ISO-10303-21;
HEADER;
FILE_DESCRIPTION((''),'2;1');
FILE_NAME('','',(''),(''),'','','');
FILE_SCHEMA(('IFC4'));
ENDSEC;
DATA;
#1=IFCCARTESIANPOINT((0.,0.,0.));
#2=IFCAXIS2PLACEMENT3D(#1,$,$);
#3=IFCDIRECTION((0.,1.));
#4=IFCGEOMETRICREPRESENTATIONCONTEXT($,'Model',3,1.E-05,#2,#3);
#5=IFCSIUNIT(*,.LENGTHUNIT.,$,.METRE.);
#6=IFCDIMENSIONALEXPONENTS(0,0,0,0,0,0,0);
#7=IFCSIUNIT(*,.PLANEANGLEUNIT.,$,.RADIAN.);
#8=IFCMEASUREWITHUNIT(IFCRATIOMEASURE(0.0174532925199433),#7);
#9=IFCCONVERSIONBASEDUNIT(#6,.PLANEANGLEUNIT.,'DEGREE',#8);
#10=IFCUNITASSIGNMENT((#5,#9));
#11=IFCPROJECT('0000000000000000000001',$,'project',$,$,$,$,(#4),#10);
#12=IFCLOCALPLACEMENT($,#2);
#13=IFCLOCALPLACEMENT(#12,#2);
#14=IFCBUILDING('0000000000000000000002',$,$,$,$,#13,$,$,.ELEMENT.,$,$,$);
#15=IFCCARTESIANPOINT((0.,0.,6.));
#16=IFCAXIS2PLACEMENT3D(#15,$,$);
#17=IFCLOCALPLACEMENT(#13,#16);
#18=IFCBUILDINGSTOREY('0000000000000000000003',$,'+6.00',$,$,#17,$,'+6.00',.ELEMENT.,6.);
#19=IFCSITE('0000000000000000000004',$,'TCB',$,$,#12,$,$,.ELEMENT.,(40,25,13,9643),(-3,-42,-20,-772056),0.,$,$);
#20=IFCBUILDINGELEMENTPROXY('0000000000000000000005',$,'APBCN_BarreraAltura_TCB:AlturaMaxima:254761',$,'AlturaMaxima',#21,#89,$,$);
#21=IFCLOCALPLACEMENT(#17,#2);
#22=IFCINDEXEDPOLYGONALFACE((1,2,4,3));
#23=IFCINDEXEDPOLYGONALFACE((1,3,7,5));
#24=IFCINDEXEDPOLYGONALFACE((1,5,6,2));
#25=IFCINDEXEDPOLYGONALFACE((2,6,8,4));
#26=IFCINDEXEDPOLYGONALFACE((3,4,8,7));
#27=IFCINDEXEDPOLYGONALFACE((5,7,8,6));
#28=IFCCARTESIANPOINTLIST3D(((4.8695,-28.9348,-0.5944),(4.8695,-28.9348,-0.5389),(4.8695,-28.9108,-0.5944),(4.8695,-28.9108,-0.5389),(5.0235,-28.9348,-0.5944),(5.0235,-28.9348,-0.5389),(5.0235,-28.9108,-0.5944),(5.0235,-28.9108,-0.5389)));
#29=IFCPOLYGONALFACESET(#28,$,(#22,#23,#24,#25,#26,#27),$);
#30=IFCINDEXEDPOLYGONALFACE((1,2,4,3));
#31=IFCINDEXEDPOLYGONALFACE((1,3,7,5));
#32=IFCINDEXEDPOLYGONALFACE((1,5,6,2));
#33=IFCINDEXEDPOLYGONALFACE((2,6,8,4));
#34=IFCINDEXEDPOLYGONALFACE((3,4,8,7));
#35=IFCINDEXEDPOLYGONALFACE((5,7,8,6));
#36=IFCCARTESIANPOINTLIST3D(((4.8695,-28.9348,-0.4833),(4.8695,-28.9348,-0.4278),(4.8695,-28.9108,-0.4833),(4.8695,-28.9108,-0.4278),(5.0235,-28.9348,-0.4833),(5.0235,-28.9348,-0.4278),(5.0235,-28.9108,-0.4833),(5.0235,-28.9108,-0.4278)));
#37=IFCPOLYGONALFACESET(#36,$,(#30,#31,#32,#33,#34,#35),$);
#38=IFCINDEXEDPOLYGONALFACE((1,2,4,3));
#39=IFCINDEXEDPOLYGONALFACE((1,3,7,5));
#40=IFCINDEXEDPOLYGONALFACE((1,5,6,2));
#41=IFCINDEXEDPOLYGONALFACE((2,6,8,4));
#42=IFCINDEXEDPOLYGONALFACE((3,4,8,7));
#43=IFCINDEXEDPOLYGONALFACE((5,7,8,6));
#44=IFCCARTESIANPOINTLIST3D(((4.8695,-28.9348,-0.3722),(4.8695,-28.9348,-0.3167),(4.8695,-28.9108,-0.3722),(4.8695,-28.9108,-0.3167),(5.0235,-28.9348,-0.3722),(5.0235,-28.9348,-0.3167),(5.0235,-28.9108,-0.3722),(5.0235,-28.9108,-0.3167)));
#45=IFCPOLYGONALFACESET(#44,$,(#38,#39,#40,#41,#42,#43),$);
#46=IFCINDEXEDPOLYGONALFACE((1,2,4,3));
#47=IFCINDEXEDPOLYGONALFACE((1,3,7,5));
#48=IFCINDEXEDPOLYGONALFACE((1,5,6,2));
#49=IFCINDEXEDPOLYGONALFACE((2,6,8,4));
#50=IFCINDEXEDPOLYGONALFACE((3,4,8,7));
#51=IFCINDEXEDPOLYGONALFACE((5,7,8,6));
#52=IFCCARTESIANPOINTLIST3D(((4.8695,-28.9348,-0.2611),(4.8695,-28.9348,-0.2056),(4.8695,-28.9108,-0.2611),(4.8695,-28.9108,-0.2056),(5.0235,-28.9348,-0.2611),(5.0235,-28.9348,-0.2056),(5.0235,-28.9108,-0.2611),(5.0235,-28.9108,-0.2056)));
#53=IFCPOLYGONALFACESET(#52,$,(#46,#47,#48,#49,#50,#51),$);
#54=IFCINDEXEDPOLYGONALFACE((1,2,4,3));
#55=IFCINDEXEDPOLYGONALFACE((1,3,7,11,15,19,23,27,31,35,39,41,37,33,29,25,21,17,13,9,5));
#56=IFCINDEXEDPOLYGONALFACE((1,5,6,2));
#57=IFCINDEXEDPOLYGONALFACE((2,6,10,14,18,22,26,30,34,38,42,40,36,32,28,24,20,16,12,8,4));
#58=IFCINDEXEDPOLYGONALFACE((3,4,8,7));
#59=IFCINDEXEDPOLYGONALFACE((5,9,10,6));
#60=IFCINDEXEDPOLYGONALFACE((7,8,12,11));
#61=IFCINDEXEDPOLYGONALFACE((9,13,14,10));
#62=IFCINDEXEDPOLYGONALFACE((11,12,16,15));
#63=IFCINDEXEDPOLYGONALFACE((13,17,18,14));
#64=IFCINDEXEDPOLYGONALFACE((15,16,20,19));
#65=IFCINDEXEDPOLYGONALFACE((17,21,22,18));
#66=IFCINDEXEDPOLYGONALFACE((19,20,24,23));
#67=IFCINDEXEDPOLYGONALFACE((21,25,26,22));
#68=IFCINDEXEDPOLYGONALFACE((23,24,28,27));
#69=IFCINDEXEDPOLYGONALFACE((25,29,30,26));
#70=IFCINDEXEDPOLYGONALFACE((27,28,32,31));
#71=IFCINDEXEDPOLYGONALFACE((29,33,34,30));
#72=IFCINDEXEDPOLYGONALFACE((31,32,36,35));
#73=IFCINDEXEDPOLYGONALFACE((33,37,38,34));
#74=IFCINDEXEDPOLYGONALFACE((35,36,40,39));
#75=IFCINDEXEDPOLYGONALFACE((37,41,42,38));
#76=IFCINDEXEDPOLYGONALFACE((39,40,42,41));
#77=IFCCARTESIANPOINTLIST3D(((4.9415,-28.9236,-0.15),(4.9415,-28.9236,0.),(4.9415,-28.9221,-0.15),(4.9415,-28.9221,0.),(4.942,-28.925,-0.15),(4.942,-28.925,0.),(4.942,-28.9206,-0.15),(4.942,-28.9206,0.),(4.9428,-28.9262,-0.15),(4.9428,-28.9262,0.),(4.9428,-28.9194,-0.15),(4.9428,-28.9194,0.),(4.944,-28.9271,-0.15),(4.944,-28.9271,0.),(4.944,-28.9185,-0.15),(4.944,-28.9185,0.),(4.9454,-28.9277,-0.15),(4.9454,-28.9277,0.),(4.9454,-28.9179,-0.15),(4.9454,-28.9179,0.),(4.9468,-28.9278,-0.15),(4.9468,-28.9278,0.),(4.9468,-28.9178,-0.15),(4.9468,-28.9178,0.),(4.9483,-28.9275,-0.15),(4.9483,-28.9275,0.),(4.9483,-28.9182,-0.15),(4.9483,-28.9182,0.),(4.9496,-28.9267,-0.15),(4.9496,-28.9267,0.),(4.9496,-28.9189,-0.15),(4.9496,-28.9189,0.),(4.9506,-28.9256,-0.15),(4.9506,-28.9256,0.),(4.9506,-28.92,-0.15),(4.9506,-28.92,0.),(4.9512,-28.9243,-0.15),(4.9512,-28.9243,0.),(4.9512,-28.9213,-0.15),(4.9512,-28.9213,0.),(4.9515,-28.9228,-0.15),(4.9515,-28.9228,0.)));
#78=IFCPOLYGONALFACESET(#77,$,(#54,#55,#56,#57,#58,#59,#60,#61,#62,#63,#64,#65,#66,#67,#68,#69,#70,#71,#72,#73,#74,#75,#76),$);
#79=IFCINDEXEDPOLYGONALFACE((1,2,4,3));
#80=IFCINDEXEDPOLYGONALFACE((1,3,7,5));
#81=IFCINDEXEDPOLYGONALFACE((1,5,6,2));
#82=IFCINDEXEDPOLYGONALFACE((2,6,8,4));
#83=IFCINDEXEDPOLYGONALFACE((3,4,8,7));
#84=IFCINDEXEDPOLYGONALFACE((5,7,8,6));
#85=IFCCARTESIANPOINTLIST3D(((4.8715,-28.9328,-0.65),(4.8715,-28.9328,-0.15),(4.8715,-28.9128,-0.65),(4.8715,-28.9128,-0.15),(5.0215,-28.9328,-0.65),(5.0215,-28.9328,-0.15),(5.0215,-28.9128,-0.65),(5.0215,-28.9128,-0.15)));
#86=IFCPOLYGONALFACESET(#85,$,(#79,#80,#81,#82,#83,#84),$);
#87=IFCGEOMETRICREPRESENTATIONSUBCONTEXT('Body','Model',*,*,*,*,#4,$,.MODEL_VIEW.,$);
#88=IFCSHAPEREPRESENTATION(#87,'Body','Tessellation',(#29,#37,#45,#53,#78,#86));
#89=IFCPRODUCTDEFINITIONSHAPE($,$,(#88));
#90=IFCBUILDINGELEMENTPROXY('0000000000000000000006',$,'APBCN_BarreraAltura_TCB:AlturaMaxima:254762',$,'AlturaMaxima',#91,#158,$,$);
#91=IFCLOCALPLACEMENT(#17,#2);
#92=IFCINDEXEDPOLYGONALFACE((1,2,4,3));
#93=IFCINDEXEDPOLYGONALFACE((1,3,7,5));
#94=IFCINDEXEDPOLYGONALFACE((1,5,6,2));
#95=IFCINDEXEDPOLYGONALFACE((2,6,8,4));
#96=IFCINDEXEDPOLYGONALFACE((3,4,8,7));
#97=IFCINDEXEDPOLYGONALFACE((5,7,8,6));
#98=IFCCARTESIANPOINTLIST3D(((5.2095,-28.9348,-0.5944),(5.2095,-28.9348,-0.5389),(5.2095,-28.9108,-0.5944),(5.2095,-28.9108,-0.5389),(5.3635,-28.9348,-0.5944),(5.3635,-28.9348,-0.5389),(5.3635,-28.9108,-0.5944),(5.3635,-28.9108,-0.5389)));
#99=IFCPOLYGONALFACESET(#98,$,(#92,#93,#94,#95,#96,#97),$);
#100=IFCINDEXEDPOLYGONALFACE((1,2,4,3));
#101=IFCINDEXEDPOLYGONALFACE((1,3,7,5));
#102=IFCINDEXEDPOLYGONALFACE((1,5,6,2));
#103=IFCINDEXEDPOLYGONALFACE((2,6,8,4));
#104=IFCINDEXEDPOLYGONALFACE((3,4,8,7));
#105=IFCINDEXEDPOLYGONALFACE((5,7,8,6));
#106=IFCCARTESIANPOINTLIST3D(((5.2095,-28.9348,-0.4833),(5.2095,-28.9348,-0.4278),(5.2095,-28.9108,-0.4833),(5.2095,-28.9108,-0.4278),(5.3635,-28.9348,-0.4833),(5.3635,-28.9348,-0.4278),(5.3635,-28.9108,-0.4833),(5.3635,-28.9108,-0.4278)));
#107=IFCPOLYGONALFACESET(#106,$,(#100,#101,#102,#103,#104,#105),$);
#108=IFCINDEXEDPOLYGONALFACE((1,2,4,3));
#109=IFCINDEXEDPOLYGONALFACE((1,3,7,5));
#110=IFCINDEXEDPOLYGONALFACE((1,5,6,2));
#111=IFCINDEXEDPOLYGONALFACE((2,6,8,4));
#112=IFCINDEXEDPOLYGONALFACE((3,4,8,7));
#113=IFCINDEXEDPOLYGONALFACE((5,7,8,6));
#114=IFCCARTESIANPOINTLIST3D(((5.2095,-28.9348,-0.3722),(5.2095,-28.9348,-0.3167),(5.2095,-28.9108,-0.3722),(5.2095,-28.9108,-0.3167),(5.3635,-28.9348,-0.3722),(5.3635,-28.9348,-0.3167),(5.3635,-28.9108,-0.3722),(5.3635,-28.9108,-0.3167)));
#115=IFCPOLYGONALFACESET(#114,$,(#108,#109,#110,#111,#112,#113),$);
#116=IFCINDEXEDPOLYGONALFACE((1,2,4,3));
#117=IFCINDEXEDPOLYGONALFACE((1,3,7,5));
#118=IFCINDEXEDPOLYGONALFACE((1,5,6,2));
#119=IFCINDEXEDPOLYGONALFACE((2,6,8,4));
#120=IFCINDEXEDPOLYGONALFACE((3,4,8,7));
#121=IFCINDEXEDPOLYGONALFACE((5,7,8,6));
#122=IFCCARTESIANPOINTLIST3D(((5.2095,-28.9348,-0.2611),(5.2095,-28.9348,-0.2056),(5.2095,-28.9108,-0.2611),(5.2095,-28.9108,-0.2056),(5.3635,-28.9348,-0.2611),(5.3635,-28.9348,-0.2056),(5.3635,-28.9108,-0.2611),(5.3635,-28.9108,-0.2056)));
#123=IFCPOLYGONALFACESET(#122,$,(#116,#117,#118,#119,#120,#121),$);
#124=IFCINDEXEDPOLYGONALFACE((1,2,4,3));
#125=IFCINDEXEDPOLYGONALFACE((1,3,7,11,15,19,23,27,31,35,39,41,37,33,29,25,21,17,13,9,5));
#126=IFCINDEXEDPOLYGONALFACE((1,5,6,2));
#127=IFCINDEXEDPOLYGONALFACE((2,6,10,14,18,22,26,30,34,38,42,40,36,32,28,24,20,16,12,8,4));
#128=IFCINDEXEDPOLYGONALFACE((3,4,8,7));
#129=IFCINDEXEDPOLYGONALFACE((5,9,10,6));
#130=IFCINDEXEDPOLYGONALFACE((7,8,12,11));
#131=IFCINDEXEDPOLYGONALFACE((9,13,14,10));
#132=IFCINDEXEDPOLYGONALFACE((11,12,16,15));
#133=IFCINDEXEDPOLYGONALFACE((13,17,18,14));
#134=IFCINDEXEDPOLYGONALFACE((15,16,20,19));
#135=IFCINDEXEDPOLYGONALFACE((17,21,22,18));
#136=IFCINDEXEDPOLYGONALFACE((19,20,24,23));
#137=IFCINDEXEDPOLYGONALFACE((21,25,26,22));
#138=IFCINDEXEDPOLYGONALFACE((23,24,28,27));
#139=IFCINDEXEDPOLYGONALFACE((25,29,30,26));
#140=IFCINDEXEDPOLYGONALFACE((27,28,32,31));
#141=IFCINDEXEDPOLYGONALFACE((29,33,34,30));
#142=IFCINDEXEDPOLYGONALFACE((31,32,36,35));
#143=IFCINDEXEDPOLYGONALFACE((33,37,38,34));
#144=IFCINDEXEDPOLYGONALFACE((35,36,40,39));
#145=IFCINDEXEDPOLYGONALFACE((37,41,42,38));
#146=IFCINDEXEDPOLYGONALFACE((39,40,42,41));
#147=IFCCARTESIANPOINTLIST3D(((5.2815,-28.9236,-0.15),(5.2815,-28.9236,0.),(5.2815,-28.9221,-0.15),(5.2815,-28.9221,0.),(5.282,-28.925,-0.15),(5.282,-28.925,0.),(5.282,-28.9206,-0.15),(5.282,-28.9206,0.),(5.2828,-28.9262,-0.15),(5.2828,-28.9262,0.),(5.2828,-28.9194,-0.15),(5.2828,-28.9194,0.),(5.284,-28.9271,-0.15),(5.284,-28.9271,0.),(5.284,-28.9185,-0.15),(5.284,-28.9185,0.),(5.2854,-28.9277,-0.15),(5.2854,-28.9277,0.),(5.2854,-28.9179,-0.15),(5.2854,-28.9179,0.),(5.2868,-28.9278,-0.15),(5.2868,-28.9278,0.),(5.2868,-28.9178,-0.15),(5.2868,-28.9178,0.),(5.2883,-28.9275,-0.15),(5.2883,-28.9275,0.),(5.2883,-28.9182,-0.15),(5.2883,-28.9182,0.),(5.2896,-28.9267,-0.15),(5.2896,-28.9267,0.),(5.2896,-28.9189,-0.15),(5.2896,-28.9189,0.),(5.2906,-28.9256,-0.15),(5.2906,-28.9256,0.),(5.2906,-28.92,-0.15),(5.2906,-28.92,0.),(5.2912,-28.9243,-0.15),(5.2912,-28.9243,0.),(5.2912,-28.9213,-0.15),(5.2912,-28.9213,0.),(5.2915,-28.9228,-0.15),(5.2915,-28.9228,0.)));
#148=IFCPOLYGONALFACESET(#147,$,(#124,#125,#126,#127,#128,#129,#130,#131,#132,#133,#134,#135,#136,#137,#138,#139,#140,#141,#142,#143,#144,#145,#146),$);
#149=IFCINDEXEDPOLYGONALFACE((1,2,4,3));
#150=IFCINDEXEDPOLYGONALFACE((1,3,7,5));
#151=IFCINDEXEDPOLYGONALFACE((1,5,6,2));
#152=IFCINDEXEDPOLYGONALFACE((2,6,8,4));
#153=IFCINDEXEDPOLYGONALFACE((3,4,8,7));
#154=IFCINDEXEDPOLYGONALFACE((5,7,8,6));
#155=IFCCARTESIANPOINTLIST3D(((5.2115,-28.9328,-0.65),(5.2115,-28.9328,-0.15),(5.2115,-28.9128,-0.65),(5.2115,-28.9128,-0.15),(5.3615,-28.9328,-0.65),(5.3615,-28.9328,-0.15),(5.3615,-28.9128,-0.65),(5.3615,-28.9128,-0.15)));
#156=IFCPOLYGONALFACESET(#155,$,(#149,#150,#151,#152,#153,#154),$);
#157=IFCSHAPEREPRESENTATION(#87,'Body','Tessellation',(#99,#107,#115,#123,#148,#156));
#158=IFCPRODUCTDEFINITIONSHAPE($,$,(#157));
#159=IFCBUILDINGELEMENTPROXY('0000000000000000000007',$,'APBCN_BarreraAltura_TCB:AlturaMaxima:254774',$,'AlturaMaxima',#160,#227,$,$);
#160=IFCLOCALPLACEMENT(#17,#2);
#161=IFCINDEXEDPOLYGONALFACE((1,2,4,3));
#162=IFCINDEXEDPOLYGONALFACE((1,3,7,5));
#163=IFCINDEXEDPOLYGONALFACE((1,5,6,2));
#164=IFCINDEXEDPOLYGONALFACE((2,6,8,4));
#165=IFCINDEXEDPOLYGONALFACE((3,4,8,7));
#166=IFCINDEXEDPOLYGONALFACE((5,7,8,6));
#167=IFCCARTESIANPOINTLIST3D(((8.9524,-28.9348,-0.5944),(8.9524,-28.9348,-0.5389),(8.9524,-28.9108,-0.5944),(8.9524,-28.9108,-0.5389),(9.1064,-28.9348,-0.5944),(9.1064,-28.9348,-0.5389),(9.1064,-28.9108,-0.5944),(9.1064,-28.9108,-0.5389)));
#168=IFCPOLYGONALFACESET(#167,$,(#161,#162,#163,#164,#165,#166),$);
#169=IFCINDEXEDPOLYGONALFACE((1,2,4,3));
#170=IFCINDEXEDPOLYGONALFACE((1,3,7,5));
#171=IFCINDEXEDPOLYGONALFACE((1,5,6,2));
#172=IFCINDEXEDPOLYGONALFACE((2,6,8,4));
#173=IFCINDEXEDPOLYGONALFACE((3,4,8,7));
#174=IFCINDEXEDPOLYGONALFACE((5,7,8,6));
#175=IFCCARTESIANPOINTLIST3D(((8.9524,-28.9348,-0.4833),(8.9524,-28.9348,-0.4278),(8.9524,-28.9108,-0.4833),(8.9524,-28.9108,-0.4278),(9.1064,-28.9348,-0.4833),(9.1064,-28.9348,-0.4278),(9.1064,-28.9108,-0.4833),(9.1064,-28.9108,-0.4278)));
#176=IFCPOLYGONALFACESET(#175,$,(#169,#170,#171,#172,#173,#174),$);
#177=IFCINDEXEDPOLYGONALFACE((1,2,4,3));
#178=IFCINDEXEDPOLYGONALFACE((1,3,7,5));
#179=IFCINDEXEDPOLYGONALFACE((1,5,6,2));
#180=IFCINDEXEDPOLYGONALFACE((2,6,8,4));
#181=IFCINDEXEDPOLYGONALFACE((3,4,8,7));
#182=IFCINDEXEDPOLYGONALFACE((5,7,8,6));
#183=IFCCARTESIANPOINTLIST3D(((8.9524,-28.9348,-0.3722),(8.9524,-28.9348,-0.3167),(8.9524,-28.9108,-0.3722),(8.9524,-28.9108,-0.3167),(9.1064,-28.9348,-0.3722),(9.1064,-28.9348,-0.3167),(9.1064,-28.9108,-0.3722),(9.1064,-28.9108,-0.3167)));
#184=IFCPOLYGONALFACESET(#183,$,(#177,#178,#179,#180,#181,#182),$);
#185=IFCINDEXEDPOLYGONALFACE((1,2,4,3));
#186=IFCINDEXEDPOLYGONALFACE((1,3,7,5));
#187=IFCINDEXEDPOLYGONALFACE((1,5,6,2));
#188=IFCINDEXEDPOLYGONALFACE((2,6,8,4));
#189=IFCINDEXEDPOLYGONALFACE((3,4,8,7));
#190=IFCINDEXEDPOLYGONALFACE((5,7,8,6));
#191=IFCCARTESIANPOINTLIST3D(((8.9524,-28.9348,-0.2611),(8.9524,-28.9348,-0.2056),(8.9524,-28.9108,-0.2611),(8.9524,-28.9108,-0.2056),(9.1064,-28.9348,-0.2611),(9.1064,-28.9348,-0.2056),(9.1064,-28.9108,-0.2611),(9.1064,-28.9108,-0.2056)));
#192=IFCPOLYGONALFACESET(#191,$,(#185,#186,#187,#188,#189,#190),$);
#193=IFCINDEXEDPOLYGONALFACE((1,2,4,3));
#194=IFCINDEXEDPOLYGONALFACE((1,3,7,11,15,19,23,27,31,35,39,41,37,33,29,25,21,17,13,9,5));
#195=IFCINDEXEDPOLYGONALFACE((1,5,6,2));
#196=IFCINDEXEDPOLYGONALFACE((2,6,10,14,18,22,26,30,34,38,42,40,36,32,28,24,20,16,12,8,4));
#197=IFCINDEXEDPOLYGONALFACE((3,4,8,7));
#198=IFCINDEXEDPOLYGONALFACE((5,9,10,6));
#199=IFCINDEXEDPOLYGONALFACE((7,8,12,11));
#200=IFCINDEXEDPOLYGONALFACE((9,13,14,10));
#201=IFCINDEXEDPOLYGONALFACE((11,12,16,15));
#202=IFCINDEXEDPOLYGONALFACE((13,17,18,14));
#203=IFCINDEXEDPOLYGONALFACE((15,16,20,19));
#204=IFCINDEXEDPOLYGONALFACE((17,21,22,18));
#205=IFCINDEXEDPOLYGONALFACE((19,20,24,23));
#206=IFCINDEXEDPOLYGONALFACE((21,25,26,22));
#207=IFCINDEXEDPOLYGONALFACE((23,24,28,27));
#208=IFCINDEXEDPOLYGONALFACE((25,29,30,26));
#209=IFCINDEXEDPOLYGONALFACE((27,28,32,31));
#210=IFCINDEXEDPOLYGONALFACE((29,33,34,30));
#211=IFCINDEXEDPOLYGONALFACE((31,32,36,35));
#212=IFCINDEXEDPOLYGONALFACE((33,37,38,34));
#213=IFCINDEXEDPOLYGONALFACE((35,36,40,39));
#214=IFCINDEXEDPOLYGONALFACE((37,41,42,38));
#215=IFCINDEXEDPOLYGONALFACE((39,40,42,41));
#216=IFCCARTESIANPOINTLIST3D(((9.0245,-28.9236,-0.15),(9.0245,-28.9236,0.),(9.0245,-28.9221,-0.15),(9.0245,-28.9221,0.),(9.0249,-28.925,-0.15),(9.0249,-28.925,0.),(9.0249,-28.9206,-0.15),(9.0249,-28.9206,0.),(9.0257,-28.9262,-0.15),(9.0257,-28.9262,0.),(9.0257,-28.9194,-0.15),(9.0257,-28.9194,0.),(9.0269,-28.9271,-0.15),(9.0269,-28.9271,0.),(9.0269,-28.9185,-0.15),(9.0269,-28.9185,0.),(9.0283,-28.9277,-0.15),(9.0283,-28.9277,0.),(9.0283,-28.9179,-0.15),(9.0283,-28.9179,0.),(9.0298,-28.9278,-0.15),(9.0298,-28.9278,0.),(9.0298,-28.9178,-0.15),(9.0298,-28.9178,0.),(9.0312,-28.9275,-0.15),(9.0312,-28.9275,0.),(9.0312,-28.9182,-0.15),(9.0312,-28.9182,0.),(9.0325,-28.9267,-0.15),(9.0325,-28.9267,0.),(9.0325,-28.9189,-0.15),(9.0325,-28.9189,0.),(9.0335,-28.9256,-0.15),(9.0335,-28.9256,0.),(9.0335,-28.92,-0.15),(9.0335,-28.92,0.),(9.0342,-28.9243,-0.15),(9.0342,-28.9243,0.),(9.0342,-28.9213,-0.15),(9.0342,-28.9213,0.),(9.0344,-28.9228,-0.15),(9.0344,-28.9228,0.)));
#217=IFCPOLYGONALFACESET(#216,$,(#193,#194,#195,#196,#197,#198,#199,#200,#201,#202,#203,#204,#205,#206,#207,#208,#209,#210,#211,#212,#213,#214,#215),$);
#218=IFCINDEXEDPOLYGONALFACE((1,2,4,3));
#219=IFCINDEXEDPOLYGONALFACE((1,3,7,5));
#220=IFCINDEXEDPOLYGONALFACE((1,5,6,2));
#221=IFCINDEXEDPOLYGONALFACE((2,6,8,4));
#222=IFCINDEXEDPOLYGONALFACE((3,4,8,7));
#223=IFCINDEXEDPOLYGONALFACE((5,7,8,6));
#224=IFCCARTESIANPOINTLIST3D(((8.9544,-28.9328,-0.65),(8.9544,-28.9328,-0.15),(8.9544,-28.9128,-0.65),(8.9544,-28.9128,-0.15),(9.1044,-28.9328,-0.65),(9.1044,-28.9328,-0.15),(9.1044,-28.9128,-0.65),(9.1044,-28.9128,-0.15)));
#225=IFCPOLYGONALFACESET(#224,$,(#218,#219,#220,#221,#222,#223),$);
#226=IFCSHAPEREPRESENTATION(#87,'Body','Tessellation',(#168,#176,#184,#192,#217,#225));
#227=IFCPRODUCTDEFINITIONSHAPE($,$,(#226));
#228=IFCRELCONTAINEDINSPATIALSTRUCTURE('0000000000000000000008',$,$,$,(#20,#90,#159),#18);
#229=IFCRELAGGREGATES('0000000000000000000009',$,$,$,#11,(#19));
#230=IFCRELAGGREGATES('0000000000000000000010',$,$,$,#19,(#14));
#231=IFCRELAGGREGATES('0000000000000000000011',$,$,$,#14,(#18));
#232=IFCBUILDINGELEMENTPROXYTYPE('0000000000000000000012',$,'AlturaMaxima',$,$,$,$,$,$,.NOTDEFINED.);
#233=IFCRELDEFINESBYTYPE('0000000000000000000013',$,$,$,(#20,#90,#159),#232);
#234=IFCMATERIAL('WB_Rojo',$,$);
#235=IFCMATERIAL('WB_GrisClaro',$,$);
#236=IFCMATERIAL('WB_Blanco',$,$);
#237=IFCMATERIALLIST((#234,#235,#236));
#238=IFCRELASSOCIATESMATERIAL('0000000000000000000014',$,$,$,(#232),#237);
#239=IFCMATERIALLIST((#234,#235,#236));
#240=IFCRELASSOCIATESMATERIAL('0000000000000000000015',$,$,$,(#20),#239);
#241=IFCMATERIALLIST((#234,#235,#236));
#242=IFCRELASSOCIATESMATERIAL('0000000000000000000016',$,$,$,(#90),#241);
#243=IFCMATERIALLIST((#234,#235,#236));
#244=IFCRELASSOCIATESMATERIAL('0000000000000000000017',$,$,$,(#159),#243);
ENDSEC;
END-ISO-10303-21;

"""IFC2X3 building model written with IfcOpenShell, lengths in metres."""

from ifc_helpers import new_model, entity, si_unit, converted_unit, direction, frame, frame_2d, origin, origin_2d_with_axis, place, context, subcontext, project, spatial, rectangle, circle, extrude, source, transform, mapped, material, material_list, type_object, type_shapes, element, save


model = new_model("IFC2X3")

# Units and contexts
model_context = context("Model", 3, precision=1e-05, world=origin(), true_north=direction((0.0, 1.0)))
body_context = subcontext(model_context, "Body", "Model", "MODEL_VIEW")
ifc_project = project(units=[si_unit("LENGTHUNIT", "METRE"), converted_unit("PLANEANGLEUNIT", "DEGREE", entity("IfcRatioMeasure", 0.0174532925199433), si_unit("PLANEANGLEUNIT", "RADIAN"), dimensions=[0, 0, 0, 0, 0, 0, 0])], contexts=[model_context])

# Site, building, storey
site_placement = place(None, origin())
site = spatial("IfcSite", under=ifc_project, at=site_placement, Name="TCB", CompositionType="ELEMENT", RefLatitude=(40, 25, 13, 9643), RefLongitude=(-3, -42, -20, -772056), RefElevation=0.0)
building_placement = place(site_placement, origin())
building = spatial("IfcBuilding", under=site, at=building_placement, CompositionType="ELEMENT")
storey_placement = place(building_placement, frame((0.0, 0.0, 6.0)))
storey = spatial("IfcBuildingStorey", under=building, at=storey_placement, Name="+6.00", LongName="+6.00", CompositionType="ELEMENT", Elevation=6.0)

# Building element proxies
ifc_material_1 = material(Name="WB_Rojo")
ifc_material_2 = material(Name="WB_GrisClaro")
ifc_material_3 = material(Name="WB_Blanco")
ifc_material_list_1 = material_list([ifc_material_1, ifc_material_2, ifc_material_3])
building_element_proxy_type = type_object("IfcBuildingElementProxyType", Name="AlturaMaxima", PredefinedType="NOTDEFINED", material=ifc_material_list_1)
shared_shape = source(origin(), body_context, "Body", "SweptSolid", [
    extrude(rectangle(XDim=0.154, YDim=0.024, at=frame_2d((0.0, 0.0), x_axis=(1.0, 0.0))), frame((0.0, 0.0, -0.5944), z_axis=(0.0, 0.0, 1.0), x_axis=(-1.0, 0.0, 0.0)), (0.0, 0.0, 1.0), 0.0556),
    extrude(rectangle(XDim=0.154, YDim=0.024, at=frame_2d((0.0, 0.0), x_axis=(1.0, 0.0))), frame((0.0, 0.0, -0.4833), z_axis=(0.0, 0.0, 1.0), x_axis=(-1.0, 0.0, 0.0)), (0.0, 0.0, 1.0), 0.0556),
    extrude(rectangle(XDim=0.154, YDim=0.024, at=frame_2d((0.0, 0.0), x_axis=(1.0, 0.0))), frame((0.0, 0.0, -0.3722), z_axis=(0.0, 0.0, 1.0), x_axis=(-1.0, 0.0, 0.0)), (0.0, 0.0, 1.0), 0.0556),
    extrude(rectangle(XDim=0.154, YDim=0.024, at=frame_2d((0.0, 0.0), x_axis=(1.0, 0.0))), frame((0.0, 0.0, -0.2611), z_axis=(0.0, 0.0, 1.0), x_axis=(-1.0, 0.0, 0.0)), (0.0, 0.0, 1.0), 0.0556),
    extrude(circle(Radius=0.005, at=frame_2d((0.0, 0.0), x_axis=(1.0, 0.0))), frame((0.0, 0.0, -0.15)), (0.0, 0.0, 1.0), 0.15),
    extrude(rectangle(XDim=0.02, YDim=0.15, at=origin_2d_with_axis()), frame((0.0, 0.0, -0.65), z_axis=(0.0, 0.0, 1.0), x_axis=(0.0, 1.0, 0.0)), (0.0, 0.0, 1.0), 0.5),
])
type_shapes(building_element_proxy_type, [shared_shape])
ifc_material_list_2 = material_list([ifc_material_1, ifc_material_2, ifc_material_3])
proxy_1_placement = place(storey_placement, frame((4.9465, -28.9228, 0.0)))
element("IfcBuildingElementProxy", 1, at=proxy_1_placement, inside=storey, type_object=building_element_proxy_type, material=ifc_material_list_2, Name="APBCN_BarreraAltura_TCB:AlturaMaxima:254761", ObjectType="AlturaMaxima", context=body_context, shape_type="MappedRepresentation", body=[
    mapped(shared_shape, transform((0.0, 0.0, 0.0), scale=1.0)),
])
ifc_material_list_3 = material_list([ifc_material_1, ifc_material_2, ifc_material_3])
proxy_2_placement = place(storey_placement, frame((5.2865, -28.9228, 0.0)))
element("IfcBuildingElementProxy", 2, at=proxy_2_placement, inside=storey, type_object=building_element_proxy_type, material=ifc_material_list_3, Name="APBCN_BarreraAltura_TCB:AlturaMaxima:254762", ObjectType="AlturaMaxima", context=body_context, shape_type="MappedRepresentation", body=[
    mapped(shared_shape, transform((0.0, 0.0, 0.0), scale=1.0)),
])
ifc_material_list_4 = material_list([ifc_material_1, ifc_material_2, ifc_material_3])
proxy_3_placement = place(storey_placement, frame((9.0294, -28.9228, 0.0)))
element("IfcBuildingElementProxy", 3, at=proxy_3_placement, inside=storey, type_object=building_element_proxy_type, material=ifc_material_list_4, Name="APBCN_BarreraAltura_TCB:AlturaMaxima:254774", ObjectType="AlturaMaxima", context=body_context, shape_type="MappedRepresentation", body=[
    mapped(shared_shape, transform((0.0, 0.0, 0.0), scale=1.0)),
])

save(model, "model.ifc")
